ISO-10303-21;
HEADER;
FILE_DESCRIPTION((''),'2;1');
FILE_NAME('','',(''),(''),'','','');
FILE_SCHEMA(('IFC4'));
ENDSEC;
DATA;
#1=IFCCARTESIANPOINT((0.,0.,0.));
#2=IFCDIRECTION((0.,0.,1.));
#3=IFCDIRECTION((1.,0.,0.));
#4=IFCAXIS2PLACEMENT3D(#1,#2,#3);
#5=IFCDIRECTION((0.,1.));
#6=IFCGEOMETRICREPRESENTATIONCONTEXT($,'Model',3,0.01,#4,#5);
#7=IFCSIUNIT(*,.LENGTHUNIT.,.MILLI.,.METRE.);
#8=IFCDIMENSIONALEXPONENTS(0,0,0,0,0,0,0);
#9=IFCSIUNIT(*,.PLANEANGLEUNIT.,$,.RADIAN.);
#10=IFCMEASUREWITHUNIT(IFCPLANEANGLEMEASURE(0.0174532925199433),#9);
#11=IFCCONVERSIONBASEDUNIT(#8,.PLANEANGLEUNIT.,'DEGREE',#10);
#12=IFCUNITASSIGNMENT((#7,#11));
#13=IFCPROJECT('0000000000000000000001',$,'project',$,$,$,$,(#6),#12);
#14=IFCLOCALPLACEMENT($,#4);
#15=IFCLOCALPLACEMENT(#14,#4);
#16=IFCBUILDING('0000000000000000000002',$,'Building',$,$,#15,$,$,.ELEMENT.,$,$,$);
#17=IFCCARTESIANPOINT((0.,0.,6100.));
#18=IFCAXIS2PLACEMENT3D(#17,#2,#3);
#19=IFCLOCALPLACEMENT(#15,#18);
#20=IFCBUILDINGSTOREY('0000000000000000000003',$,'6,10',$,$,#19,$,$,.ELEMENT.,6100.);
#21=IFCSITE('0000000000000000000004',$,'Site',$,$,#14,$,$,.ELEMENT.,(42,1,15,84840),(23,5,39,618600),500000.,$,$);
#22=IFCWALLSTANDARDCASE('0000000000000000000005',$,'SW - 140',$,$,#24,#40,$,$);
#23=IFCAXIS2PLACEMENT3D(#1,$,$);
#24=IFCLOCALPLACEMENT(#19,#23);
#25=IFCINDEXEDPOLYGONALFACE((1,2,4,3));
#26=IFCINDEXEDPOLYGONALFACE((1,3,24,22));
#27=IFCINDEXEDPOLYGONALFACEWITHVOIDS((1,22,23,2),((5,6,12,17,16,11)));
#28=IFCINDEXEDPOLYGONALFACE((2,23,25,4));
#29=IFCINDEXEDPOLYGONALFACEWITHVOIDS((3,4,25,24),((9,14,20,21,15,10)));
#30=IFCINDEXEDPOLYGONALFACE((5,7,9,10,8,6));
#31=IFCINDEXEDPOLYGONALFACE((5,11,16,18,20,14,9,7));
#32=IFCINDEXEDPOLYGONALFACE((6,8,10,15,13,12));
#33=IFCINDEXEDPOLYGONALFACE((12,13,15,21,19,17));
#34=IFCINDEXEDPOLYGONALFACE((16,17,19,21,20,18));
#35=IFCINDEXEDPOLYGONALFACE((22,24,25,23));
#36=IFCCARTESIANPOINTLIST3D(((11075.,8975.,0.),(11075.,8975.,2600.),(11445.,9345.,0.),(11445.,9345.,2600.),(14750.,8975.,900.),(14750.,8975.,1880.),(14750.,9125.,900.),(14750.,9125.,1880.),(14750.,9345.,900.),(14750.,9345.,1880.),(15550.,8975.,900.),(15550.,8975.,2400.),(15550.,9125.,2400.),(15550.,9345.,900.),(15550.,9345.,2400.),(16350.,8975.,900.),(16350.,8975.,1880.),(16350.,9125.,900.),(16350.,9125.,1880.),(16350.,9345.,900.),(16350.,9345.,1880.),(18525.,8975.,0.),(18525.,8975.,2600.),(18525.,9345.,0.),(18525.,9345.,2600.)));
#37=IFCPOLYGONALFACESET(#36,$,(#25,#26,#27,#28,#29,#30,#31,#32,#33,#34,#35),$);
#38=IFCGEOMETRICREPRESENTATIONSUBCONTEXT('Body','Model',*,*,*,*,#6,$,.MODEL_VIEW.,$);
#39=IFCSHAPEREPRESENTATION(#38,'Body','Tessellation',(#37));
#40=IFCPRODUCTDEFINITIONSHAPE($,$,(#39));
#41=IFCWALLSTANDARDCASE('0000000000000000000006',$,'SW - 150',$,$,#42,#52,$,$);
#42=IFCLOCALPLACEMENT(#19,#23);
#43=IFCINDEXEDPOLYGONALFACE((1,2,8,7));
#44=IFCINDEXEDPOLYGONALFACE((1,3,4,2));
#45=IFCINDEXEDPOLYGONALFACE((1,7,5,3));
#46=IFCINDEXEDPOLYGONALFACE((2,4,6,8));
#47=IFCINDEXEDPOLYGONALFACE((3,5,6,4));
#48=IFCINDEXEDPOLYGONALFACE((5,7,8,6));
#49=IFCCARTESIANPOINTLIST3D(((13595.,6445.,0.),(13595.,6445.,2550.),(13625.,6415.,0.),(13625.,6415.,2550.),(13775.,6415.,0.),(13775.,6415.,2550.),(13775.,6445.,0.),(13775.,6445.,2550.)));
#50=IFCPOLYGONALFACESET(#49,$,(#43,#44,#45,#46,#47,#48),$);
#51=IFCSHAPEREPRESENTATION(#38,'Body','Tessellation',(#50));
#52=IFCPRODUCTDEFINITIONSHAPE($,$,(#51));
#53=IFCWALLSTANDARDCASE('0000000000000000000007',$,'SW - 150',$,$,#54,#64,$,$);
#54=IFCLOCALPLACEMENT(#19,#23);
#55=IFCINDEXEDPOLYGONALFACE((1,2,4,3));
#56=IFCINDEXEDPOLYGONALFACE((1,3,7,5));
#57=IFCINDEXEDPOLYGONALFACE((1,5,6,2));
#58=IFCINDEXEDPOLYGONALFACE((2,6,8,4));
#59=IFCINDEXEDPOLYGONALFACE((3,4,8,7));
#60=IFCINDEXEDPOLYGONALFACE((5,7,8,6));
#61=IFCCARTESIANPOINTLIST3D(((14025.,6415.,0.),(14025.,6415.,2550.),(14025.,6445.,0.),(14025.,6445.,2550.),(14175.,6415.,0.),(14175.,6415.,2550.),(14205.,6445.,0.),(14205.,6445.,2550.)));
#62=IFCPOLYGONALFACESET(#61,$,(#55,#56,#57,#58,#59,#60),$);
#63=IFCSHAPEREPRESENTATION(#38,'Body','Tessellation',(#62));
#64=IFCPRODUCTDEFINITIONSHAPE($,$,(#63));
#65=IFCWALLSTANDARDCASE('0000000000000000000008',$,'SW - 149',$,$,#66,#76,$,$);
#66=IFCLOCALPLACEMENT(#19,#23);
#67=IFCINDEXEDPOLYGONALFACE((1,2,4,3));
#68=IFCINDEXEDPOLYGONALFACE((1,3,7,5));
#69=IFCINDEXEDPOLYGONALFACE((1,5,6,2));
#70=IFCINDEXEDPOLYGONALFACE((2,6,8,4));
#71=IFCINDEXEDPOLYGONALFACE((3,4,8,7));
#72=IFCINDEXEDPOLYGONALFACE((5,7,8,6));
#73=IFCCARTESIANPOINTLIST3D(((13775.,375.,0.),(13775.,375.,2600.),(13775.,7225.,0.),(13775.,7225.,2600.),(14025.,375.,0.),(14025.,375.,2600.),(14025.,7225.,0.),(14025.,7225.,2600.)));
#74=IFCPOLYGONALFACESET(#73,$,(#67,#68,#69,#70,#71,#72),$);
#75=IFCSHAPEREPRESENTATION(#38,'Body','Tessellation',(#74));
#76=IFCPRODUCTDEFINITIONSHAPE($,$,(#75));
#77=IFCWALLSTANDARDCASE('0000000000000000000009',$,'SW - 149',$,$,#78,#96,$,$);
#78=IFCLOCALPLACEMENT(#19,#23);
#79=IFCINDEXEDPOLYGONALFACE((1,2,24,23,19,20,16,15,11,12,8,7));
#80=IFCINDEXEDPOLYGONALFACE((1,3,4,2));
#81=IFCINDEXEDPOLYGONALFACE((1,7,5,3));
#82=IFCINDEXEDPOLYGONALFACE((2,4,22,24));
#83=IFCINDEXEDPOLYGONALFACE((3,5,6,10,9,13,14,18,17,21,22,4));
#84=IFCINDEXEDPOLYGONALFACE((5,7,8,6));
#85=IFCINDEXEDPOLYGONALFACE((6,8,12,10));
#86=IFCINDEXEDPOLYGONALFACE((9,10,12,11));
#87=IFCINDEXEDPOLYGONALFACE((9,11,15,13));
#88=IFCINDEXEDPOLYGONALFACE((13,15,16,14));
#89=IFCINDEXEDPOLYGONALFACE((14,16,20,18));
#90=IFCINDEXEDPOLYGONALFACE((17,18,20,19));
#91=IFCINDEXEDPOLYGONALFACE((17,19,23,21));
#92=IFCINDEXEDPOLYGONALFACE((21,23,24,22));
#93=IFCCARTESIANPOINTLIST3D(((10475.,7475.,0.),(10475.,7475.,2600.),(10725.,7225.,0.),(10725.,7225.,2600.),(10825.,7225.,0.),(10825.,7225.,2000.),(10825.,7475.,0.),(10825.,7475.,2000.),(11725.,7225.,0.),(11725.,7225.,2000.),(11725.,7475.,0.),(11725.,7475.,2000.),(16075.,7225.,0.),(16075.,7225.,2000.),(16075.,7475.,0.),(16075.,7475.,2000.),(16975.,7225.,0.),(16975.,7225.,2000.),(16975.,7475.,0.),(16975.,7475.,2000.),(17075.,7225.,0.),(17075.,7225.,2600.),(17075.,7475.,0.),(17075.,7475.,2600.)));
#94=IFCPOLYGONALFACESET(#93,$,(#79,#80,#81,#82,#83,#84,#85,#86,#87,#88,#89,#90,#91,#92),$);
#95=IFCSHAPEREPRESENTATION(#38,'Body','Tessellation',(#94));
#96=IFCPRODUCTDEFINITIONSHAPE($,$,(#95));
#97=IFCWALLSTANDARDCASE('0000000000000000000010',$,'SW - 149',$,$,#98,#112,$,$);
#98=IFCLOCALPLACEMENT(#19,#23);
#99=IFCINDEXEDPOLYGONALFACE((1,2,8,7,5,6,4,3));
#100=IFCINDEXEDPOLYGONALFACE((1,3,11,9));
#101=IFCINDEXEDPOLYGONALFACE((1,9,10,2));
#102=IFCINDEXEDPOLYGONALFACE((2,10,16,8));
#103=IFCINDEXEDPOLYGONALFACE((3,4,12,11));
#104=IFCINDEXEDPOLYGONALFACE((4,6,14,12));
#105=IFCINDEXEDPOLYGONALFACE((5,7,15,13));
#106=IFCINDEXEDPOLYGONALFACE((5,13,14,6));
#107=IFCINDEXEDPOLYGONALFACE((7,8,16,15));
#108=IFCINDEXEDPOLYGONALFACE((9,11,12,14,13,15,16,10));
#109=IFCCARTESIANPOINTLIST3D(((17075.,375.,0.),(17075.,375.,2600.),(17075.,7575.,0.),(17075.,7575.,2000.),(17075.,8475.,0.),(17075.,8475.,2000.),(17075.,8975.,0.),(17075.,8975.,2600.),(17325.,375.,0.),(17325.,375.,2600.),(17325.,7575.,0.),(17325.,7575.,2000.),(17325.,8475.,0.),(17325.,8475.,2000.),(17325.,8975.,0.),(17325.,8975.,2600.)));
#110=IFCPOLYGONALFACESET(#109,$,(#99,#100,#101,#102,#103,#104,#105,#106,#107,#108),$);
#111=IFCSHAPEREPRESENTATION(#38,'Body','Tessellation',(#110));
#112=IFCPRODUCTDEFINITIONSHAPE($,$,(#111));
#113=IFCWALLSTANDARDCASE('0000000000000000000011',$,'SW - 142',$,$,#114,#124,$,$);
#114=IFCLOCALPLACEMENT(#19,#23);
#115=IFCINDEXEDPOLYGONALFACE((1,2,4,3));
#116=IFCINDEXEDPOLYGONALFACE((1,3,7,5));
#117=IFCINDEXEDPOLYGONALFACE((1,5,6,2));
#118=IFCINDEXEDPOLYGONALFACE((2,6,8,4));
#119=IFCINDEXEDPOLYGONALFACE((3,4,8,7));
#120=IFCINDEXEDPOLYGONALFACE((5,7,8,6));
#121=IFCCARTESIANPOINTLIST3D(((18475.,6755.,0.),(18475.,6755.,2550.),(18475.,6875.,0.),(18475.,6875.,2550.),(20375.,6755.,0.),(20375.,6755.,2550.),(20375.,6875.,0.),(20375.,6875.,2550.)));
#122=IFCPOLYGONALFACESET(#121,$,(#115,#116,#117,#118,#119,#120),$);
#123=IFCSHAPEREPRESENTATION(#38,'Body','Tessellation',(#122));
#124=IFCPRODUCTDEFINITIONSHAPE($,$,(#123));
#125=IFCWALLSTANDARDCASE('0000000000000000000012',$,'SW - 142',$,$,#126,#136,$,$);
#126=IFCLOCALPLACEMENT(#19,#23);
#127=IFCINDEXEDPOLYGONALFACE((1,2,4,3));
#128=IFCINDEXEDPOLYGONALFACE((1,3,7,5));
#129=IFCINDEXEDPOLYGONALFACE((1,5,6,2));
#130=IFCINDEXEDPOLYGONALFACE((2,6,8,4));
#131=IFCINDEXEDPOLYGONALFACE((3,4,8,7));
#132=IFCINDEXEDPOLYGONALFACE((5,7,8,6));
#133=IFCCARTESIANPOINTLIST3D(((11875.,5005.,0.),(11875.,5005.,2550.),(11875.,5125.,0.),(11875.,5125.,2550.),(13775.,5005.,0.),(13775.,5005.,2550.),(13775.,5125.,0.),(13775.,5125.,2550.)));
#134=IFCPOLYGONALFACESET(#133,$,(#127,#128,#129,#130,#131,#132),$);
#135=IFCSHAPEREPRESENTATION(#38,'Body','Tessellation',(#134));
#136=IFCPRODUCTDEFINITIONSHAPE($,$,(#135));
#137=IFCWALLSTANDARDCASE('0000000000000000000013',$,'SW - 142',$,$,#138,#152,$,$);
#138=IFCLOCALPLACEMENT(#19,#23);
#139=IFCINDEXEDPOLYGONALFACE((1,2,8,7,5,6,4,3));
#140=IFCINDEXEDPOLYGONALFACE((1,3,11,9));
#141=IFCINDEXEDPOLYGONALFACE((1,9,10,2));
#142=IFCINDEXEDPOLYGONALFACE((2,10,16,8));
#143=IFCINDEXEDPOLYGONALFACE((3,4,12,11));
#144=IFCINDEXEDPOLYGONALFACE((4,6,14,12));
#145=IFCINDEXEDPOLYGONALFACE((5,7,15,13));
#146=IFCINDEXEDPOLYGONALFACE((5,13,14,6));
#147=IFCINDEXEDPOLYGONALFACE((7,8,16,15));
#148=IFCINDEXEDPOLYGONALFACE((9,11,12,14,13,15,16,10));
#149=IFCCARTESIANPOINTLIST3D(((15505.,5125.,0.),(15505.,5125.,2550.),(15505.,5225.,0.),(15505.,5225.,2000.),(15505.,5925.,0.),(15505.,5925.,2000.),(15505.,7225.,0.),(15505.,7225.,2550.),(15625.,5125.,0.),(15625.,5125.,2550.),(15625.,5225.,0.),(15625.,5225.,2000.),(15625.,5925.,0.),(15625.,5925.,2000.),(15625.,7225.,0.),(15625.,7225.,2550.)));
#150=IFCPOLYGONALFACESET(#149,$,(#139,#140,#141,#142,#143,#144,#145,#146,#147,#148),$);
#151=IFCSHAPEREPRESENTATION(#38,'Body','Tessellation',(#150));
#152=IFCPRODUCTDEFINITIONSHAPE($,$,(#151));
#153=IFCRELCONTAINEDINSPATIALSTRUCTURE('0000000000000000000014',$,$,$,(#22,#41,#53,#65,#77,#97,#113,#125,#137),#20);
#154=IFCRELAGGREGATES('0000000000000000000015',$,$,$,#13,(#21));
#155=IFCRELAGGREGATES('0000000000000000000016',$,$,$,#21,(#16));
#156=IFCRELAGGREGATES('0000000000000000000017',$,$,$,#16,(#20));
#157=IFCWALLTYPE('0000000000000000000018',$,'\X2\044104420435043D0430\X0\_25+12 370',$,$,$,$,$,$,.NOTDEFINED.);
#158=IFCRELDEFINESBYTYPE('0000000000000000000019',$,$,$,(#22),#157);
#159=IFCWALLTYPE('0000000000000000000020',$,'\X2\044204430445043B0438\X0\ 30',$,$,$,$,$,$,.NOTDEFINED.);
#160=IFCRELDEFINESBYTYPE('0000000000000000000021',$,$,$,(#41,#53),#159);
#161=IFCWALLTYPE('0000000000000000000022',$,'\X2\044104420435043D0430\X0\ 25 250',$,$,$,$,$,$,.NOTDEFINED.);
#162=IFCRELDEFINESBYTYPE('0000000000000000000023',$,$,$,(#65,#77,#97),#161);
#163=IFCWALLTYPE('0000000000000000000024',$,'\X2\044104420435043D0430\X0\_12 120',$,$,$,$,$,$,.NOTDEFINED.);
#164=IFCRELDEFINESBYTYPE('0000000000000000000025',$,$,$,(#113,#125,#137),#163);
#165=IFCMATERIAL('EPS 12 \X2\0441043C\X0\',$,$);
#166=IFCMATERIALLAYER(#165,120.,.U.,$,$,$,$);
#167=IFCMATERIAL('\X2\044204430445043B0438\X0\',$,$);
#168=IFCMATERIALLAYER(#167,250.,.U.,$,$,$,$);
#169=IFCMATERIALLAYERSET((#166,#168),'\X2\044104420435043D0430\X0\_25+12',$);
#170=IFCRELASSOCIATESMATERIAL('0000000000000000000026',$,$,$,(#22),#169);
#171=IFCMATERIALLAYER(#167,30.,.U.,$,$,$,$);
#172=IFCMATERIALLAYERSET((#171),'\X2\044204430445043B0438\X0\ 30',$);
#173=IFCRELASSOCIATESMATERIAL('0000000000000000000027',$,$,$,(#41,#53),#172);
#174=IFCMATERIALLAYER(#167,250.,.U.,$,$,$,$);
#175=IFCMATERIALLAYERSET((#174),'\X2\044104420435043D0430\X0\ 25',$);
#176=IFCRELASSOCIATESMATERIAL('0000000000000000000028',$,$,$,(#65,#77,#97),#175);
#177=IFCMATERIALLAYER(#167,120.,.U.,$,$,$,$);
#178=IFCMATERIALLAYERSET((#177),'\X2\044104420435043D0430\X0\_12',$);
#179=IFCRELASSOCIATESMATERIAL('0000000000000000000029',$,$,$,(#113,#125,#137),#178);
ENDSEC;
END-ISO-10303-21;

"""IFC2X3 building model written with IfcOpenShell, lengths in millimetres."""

from ifc_helpers import new_model, entity, si_unit, converted_unit, direction, frame, origin_with_axes, origin_2d_with_axis, place, context, subcontext, project, spatial, polyline, rectangle, outline, extrude, material, layer, layer_set, layer_usage, type_object, element, save


model = new_model("IFC2X3")

# Units and contexts
model_context = context("Model", 3, precision=0.01, world=origin_with_axes(), true_north=direction((0.0, 1.0)))
body_context = subcontext(model_context, "Body", "Model", "MODEL_VIEW")
ifc_project = project(units=[si_unit("LENGTHUNIT", "METRE", prefix="MILLI"), converted_unit("PLANEANGLEUNIT", "DEGREE", entity("IfcPlaneAngleMeasure", 0.0174532925199433), si_unit("PLANEANGLEUNIT", "RADIAN"), dimensions=[0, 0, 0, 0, 0, 0, 0])], contexts=[model_context])

# Site, building, storey
site_placement = place(None, origin_with_axes())
site = spatial("IfcSite", under=ifc_project, at=site_placement, Name="Site", CompositionType="ELEMENT", RefLatitude=(42, 1, 15, 84840), RefLongitude=(23, 5, 39, 618600), RefElevation=500000.0)
building_placement = place(site_placement, origin_with_axes())
building = spatial("IfcBuilding", under=site, at=building_placement, Name="Building", CompositionType="ELEMENT")
storey_placement = place(building_placement, frame((0.0, 0.0, 6100.0), z_axis=(0.0, 0.0, 1.0), x_axis=(1.0, 0.0, 0.0)))
storey = spatial("IfcBuildingStorey", under=building, at=storey_placement, Name="6,10", CompositionType="ELEMENT", Elevation=6100.0)

# Shared definitions
ifc_material_1 = material(Name="EPS 12 см")
ifc_layer_1 = layer(ifc_material_1, 120.0, ventilated="UNKNOWN")
ifc_material_2 = material(Name="тухли")
ifc_layer_2 = layer(ifc_material_2, 250.0, ventilated="UNKNOWN")
ifc_layer_set_1 = layer_set([ifc_layer_1, ifc_layer_2], Name="стена_25+12")
wall_type_1 = type_object("IfcWallType", Name="стена_25+12 370", PredefinedType="NOTDEFINED")

# Wall, openings
ifc_layer_usage_1 = layer_usage(ifc_layer_set_1, "AXIS2", "POSITIVE", -120.0)
wall_1_placement = place(storey_placement, frame((18525.0, 9225.0, 0.0), z_axis=(0.0, 0.0, 1.0), x_axis=(-1.0, 0.0, 0.0)))
wall_1 = element("IfcWallStandardCase", 1, at=wall_1_placement, inside=storey, type_object=wall_type_1, material=ifc_layer_usage_1, Name="SW - 140", context=body_context, shape_type="SweptSolid", body=[
    extrude(outline(polyline([(0.0, -120.0), (7080.0, -120.0), (7450.0, 250.0), (0.0, 250.0), (0.0, -120.0)])), origin_with_axes(), (0.0, 0.0, 1.0), 2600.0),
])
opening_1_placement = place(wall_1_placement, frame((3375.0, 0.0, 900.0), z_axis=(0.0, 0.0, 1.0), x_axis=(1.0, 0.0, 0.0)))
element("IfcOpeningElement", 2, at=opening_1_placement, cuts=wall_1, context=body_context, shape_type="SweptSolid", body=[
    extrude(outline(polyline([(-400.0, 0.0), (-400.0, -1500.0), (400.0, -980.0), (400.0, 0.0), (-400.0, 0.0)])), frame((0.0, 100.0, 0.0), z_axis=(0.0, 1.0, 0.0), x_axis=(1.0, 0.0, 0.0)), (0.0, 0.0, -1.0), 590.0),
    extrude(outline(polyline([(400.0, 0.0), (400.0, 980.0), (-400.0, 1500.0), (-400.0, 0.0), (400.0, 0.0)])), frame((0.0, 100.0, 0.0), z_axis=(0.0, -1.0, 0.0), x_axis=(1.0, 0.0, 0.0)), (0.0, 0.0, -1.0), 520.0),
])
opening_2_placement = place(wall_1_placement, frame((2575.0, 0.0, 900.0), z_axis=(0.0, 0.0, 1.0), x_axis=(1.0, 0.0, 0.0)))
element("IfcOpeningElement", 3, at=opening_2_placement, cuts=wall_1, context=body_context, shape_type="SweptSolid", body=[
    extrude(outline(polyline([(-400.0, 0.0), (-400.0, -1500.0), (400.0, -980.0), (400.0, 0.0), (-400.0, 0.0)])), frame((0.0, 100.0, 0.0), z_axis=(0.0, -1.0, 0.0), x_axis=(-1.0, 0.0, 0.0)), (0.0, 0.0, 1.0), 590.0),
    extrude(outline(polyline([(400.0, 0.0), (400.0, 980.0), (-400.0, 1500.0), (-400.0, 0.0), (400.0, 0.0)])), frame((0.0, 100.0, 0.0), z_axis=(0.0, 1.0, 0.0), x_axis=(-1.0, 0.0, 0.0)), (0.0, 0.0, 1.0), 520.0),
])

# Walls
ifc_layer_3 = layer(ifc_material_2, 30.0, ventilated="UNKNOWN")
ifc_layer_set_2 = layer_set([ifc_layer_3], Name="тухли 30")
wall_type_2 = type_object("IfcWallType", Name="тухли 30", PredefinedType="NOTDEFINED")
ifc_layer_usage_2 = layer_usage(ifc_layer_set_2, "AXIS2", "NEGATIVE", 0.0)
wall_2_placement = place(storey_placement, frame((13595.0, 6445.0, 0.0), z_axis=(0.0, 0.0, 1.0), x_axis=(1.0, 0.0, 0.0)))
element("IfcWallStandardCase", 4, at=wall_2_placement, inside=storey, type_object=wall_type_2, material=ifc_layer_usage_2, Name="SW - 150", context=body_context, shape_type="SweptSolid", body=[
    extrude(outline(polyline([(30.0, -30.0), (180.0, -30.0), (180.0, 0.0), (0.0, 0.0), (30.0, -30.0)])), origin_with_axes(), (0.0, 0.0, 1.0), 2550.0),
])
ifc_layer_usage_3 = layer_usage(ifc_layer_set_2, "AXIS2", "NEGATIVE", 0.0)
wall_3_placement = place(storey_placement, frame((14025.0, 6445.0, 0.0), z_axis=(0.0, 0.0, 1.0), x_axis=(1.0, 0.0, 0.0)))
element("IfcWallStandardCase", 5, at=wall_3_placement, inside=storey, type_object=wall_type_2, material=ifc_layer_usage_3, Name="SW - 150", context=body_context, shape_type="SweptSolid", body=[
    extrude(outline(polyline([(0.0, -30.0), (150.0, -30.0), (180.0, 0.0), (0.0, 0.0), (0.0, -30.0)])), origin_with_axes(), (0.0, 0.0, 1.0), 2550.0),
])
ifc_layer_4 = layer(ifc_material_2, 250.0, ventilated="UNKNOWN")
ifc_layer_set_3 = layer_set([ifc_layer_4], Name="стена 25")
ifc_layer_usage_4 = layer_usage(ifc_layer_set_3, "AXIS2", "NEGATIVE", 0.0)
wall_type_3 = type_object("IfcWallType", Name="стена 25 250", PredefinedType="NOTDEFINED")
wall_4_placement = place(storey_placement, frame((13775.0, 125.0, 0.0), z_axis=(0.0, 0.0, 1.0), x_axis=(0.0, 1.0, 0.0)))
element("IfcWallStandardCase", 6, at=wall_4_placement, inside=storey, type_object=wall_type_3, material=ifc_layer_usage_4, Name="SW - 149", context=body_context, shape_type="SweptSolid", body=[
    extrude(outline(polyline([(250.0, -250.0), (7100.0, -250.0), (7100.0, 0.0), (250.0, 0.0), (250.0, -250.0)])), origin_with_axes(), (0.0, 0.0, 1.0), 2600.0),
])

# Wall, openings
ifc_layer_usage_5 = layer_usage(ifc_layer_set_3, "AXIS2", "NEGATIVE", 0.0)
wall_5_placement = place(storey_placement, frame((17075.0, 7225.0, 0.0), z_axis=(0.0, 0.0, 1.0), x_axis=(-1.0, 0.0, 0.0)))
wall_5 = element("IfcWallStandardCase", 7, at=wall_5_placement, inside=storey, type_object=wall_type_3, material=ifc_layer_usage_5, Name="SW - 149", context=body_context, shape_type="SweptSolid", body=[
    extrude(outline(polyline([(0.0, -250.0), (6600.0, -250.0), (6350.0, 0.0), (0.0, 0.0), (0.0, -250.0)])), origin_with_axes(), (0.0, 0.0, 1.0), 2600.0),
])
opening_3_placement = place(wall_5_placement, frame((5800.0, 0.0, 0.0), z_axis=(0.0, 0.0, 1.0), x_axis=(1.0, 0.0, 0.0)))
element("IfcOpeningElement", 8, at=opening_3_placement, cuts=wall_5, context=body_context, shape_type="SweptSolid", body=[
    extrude(rectangle(XDim=900.0, YDim=2000.0, at=origin_2d_with_axis()), frame((0.0, -250.0, 1000.0), z_axis=(0.0, 1.0, 0.0), x_axis=(1.0, 0.0, 0.0)), (0.0, 0.0, 1.0), 750.0),
])
opening_4_placement = place(wall_5_placement, frame((550.0, 0.0, 0.0), z_axis=(0.0, 0.0, 1.0), x_axis=(1.0, 0.0, 0.0)))
element("IfcOpeningElement", 9, at=opening_4_placement, cuts=wall_5, context=body_context, shape_type="SweptSolid", body=[
    extrude(rectangle(XDim=900.0, YDim=2000.0, at=origin_2d_with_axis()), frame((0.0, -250.0, 1000.0), z_axis=(0.0, -1.0, 0.0), x_axis=(-1.0, 0.0, 0.0)), (0.0, 0.0, -1.0), 750.0),
])

# Wall, opening
ifc_layer_usage_6 = layer_usage(ifc_layer_set_3, "AXIS2", "NEGATIVE", 0.0)
wall_6_placement = place(storey_placement, frame((17075.0, 125.0, 0.0), z_axis=(0.0, 0.0, 1.0), x_axis=(0.0, 1.0, 0.0)))
wall_6 = element("IfcWallStandardCase", 10, at=wall_6_placement, inside=storey, type_object=wall_type_3, material=ifc_layer_usage_6, Name="SW - 149", context=body_context, shape_type="SweptSolid", body=[
    extrude(outline(polyline([(250.0, -250.0), (8850.0, -250.0), (8850.0, 0.0), (250.0, 0.0), (250.0, -250.0)])), origin_with_axes(), (0.0, 0.0, 1.0), 2600.0),
])
opening_5_placement = place(wall_6_placement, frame((7900.0, 0.0, 0.0), z_axis=(0.0, 0.0, 1.0), x_axis=(1.0, 0.0, 0.0)))
element("IfcOpeningElement", 11, at=opening_5_placement, cuts=wall_6, context=body_context, shape_type="SweptSolid", body=[
    extrude(rectangle(XDim=900.0, YDim=2000.0, at=origin_2d_with_axis()), frame((0.0, 250.0, 1000.0), z_axis=(0.0, 1.0, 0.0), x_axis=(1.0, 0.0, 0.0)), (0.0, 0.0, -1.0), 750.0),
])

# Walls
ifc_layer_5 = layer(ifc_material_2, 120.0, ventilated="UNKNOWN")
ifc_layer_set_4 = layer_set([ifc_layer_5], Name="стена_12")
ifc_layer_usage_7 = layer_usage(ifc_layer_set_4, "AXIS2", "POSITIVE", -60.0)
wall_type_4 = type_object("IfcWallType", Name="стена_12 120", PredefinedType="NOTDEFINED")
wall_7_placement = place(storey_placement, frame((20375.0, 6815.0, 0.0), z_axis=(0.0, 0.0, 1.0), x_axis=(-1.0, 0.0, 0.0)))
element("IfcWallStandardCase", 12, at=wall_7_placement, inside=storey, type_object=wall_type_4, material=ifc_layer_usage_7, Name="SW - 142", context=body_context, shape_type="SweptSolid", body=[
    extrude(outline(polyline([(0.0, -60.0), (1900.0, -60.0), (1900.0, 60.0), (0.0, 60.0), (0.0, -60.0)])), origin_with_axes(), (0.0, 0.0, 1.0), 2550.0),
])
ifc_layer_usage_8 = layer_usage(ifc_layer_set_4, "AXIS2", "POSITIVE", -60.0)
wall_8_placement = place(storey_placement, frame((13775.0, 5065.0, 0.0), z_axis=(0.0, 0.0, 1.0), x_axis=(-1.0, 0.0, 0.0)))
element("IfcWallStandardCase", 13, at=wall_8_placement, inside=storey, type_object=wall_type_4, material=ifc_layer_usage_8, Name="SW - 142", context=body_context, shape_type="SweptSolid", body=[
    extrude(outline(polyline([(0.0, -60.0), (1900.0, -60.0), (1900.0, 60.0), (0.0, 60.0), (0.0, -60.0)])), origin_with_axes(), (0.0, 0.0, 1.0), 2550.0),
])

# Wall, opening
ifc_layer_usage_9 = layer_usage(ifc_layer_set_4, "AXIS2", "NEGATIVE", 60.0)
wall_9_placement = place(storey_placement, frame((15565.0, 7225.0, 0.0), z_axis=(0.0, 0.0, 1.0), x_axis=(0.0, -1.0, 0.0)))
wall_9 = element("IfcWallStandardCase", 14, at=wall_9_placement, inside=storey, type_object=wall_type_4, material=ifc_layer_usage_9, Name="SW - 142", context=body_context, shape_type="SweptSolid", body=[
    extrude(outline(polyline([(0.0, -60.0), (2100.0, -60.0), (2100.0, 60.0), (0.0, 60.0), (0.0, -60.0)])), origin_with_axes(), (0.0, 0.0, 1.0), 2550.0),
])
opening_6_placement = place(wall_9_placement, frame((1650.0, 0.0, 0.0), z_axis=(0.0, 0.0, 1.0), x_axis=(1.0, 0.0, 0.0)))
element("IfcOpeningElement", 15, at=opening_6_placement, cuts=wall_9, context=body_context, shape_type="SweptSolid", body=[
    extrude(rectangle(XDim=700.0, YDim=2000.0, at=origin_2d_with_axis()), frame((0.0, 120.0, 1000.0), z_axis=(0.0, 1.0, 0.0), x_axis=(1.0, 0.0, 0.0)), (0.0, 0.0, -1.0), 360.0),
])

save(model, "model.ifc")
